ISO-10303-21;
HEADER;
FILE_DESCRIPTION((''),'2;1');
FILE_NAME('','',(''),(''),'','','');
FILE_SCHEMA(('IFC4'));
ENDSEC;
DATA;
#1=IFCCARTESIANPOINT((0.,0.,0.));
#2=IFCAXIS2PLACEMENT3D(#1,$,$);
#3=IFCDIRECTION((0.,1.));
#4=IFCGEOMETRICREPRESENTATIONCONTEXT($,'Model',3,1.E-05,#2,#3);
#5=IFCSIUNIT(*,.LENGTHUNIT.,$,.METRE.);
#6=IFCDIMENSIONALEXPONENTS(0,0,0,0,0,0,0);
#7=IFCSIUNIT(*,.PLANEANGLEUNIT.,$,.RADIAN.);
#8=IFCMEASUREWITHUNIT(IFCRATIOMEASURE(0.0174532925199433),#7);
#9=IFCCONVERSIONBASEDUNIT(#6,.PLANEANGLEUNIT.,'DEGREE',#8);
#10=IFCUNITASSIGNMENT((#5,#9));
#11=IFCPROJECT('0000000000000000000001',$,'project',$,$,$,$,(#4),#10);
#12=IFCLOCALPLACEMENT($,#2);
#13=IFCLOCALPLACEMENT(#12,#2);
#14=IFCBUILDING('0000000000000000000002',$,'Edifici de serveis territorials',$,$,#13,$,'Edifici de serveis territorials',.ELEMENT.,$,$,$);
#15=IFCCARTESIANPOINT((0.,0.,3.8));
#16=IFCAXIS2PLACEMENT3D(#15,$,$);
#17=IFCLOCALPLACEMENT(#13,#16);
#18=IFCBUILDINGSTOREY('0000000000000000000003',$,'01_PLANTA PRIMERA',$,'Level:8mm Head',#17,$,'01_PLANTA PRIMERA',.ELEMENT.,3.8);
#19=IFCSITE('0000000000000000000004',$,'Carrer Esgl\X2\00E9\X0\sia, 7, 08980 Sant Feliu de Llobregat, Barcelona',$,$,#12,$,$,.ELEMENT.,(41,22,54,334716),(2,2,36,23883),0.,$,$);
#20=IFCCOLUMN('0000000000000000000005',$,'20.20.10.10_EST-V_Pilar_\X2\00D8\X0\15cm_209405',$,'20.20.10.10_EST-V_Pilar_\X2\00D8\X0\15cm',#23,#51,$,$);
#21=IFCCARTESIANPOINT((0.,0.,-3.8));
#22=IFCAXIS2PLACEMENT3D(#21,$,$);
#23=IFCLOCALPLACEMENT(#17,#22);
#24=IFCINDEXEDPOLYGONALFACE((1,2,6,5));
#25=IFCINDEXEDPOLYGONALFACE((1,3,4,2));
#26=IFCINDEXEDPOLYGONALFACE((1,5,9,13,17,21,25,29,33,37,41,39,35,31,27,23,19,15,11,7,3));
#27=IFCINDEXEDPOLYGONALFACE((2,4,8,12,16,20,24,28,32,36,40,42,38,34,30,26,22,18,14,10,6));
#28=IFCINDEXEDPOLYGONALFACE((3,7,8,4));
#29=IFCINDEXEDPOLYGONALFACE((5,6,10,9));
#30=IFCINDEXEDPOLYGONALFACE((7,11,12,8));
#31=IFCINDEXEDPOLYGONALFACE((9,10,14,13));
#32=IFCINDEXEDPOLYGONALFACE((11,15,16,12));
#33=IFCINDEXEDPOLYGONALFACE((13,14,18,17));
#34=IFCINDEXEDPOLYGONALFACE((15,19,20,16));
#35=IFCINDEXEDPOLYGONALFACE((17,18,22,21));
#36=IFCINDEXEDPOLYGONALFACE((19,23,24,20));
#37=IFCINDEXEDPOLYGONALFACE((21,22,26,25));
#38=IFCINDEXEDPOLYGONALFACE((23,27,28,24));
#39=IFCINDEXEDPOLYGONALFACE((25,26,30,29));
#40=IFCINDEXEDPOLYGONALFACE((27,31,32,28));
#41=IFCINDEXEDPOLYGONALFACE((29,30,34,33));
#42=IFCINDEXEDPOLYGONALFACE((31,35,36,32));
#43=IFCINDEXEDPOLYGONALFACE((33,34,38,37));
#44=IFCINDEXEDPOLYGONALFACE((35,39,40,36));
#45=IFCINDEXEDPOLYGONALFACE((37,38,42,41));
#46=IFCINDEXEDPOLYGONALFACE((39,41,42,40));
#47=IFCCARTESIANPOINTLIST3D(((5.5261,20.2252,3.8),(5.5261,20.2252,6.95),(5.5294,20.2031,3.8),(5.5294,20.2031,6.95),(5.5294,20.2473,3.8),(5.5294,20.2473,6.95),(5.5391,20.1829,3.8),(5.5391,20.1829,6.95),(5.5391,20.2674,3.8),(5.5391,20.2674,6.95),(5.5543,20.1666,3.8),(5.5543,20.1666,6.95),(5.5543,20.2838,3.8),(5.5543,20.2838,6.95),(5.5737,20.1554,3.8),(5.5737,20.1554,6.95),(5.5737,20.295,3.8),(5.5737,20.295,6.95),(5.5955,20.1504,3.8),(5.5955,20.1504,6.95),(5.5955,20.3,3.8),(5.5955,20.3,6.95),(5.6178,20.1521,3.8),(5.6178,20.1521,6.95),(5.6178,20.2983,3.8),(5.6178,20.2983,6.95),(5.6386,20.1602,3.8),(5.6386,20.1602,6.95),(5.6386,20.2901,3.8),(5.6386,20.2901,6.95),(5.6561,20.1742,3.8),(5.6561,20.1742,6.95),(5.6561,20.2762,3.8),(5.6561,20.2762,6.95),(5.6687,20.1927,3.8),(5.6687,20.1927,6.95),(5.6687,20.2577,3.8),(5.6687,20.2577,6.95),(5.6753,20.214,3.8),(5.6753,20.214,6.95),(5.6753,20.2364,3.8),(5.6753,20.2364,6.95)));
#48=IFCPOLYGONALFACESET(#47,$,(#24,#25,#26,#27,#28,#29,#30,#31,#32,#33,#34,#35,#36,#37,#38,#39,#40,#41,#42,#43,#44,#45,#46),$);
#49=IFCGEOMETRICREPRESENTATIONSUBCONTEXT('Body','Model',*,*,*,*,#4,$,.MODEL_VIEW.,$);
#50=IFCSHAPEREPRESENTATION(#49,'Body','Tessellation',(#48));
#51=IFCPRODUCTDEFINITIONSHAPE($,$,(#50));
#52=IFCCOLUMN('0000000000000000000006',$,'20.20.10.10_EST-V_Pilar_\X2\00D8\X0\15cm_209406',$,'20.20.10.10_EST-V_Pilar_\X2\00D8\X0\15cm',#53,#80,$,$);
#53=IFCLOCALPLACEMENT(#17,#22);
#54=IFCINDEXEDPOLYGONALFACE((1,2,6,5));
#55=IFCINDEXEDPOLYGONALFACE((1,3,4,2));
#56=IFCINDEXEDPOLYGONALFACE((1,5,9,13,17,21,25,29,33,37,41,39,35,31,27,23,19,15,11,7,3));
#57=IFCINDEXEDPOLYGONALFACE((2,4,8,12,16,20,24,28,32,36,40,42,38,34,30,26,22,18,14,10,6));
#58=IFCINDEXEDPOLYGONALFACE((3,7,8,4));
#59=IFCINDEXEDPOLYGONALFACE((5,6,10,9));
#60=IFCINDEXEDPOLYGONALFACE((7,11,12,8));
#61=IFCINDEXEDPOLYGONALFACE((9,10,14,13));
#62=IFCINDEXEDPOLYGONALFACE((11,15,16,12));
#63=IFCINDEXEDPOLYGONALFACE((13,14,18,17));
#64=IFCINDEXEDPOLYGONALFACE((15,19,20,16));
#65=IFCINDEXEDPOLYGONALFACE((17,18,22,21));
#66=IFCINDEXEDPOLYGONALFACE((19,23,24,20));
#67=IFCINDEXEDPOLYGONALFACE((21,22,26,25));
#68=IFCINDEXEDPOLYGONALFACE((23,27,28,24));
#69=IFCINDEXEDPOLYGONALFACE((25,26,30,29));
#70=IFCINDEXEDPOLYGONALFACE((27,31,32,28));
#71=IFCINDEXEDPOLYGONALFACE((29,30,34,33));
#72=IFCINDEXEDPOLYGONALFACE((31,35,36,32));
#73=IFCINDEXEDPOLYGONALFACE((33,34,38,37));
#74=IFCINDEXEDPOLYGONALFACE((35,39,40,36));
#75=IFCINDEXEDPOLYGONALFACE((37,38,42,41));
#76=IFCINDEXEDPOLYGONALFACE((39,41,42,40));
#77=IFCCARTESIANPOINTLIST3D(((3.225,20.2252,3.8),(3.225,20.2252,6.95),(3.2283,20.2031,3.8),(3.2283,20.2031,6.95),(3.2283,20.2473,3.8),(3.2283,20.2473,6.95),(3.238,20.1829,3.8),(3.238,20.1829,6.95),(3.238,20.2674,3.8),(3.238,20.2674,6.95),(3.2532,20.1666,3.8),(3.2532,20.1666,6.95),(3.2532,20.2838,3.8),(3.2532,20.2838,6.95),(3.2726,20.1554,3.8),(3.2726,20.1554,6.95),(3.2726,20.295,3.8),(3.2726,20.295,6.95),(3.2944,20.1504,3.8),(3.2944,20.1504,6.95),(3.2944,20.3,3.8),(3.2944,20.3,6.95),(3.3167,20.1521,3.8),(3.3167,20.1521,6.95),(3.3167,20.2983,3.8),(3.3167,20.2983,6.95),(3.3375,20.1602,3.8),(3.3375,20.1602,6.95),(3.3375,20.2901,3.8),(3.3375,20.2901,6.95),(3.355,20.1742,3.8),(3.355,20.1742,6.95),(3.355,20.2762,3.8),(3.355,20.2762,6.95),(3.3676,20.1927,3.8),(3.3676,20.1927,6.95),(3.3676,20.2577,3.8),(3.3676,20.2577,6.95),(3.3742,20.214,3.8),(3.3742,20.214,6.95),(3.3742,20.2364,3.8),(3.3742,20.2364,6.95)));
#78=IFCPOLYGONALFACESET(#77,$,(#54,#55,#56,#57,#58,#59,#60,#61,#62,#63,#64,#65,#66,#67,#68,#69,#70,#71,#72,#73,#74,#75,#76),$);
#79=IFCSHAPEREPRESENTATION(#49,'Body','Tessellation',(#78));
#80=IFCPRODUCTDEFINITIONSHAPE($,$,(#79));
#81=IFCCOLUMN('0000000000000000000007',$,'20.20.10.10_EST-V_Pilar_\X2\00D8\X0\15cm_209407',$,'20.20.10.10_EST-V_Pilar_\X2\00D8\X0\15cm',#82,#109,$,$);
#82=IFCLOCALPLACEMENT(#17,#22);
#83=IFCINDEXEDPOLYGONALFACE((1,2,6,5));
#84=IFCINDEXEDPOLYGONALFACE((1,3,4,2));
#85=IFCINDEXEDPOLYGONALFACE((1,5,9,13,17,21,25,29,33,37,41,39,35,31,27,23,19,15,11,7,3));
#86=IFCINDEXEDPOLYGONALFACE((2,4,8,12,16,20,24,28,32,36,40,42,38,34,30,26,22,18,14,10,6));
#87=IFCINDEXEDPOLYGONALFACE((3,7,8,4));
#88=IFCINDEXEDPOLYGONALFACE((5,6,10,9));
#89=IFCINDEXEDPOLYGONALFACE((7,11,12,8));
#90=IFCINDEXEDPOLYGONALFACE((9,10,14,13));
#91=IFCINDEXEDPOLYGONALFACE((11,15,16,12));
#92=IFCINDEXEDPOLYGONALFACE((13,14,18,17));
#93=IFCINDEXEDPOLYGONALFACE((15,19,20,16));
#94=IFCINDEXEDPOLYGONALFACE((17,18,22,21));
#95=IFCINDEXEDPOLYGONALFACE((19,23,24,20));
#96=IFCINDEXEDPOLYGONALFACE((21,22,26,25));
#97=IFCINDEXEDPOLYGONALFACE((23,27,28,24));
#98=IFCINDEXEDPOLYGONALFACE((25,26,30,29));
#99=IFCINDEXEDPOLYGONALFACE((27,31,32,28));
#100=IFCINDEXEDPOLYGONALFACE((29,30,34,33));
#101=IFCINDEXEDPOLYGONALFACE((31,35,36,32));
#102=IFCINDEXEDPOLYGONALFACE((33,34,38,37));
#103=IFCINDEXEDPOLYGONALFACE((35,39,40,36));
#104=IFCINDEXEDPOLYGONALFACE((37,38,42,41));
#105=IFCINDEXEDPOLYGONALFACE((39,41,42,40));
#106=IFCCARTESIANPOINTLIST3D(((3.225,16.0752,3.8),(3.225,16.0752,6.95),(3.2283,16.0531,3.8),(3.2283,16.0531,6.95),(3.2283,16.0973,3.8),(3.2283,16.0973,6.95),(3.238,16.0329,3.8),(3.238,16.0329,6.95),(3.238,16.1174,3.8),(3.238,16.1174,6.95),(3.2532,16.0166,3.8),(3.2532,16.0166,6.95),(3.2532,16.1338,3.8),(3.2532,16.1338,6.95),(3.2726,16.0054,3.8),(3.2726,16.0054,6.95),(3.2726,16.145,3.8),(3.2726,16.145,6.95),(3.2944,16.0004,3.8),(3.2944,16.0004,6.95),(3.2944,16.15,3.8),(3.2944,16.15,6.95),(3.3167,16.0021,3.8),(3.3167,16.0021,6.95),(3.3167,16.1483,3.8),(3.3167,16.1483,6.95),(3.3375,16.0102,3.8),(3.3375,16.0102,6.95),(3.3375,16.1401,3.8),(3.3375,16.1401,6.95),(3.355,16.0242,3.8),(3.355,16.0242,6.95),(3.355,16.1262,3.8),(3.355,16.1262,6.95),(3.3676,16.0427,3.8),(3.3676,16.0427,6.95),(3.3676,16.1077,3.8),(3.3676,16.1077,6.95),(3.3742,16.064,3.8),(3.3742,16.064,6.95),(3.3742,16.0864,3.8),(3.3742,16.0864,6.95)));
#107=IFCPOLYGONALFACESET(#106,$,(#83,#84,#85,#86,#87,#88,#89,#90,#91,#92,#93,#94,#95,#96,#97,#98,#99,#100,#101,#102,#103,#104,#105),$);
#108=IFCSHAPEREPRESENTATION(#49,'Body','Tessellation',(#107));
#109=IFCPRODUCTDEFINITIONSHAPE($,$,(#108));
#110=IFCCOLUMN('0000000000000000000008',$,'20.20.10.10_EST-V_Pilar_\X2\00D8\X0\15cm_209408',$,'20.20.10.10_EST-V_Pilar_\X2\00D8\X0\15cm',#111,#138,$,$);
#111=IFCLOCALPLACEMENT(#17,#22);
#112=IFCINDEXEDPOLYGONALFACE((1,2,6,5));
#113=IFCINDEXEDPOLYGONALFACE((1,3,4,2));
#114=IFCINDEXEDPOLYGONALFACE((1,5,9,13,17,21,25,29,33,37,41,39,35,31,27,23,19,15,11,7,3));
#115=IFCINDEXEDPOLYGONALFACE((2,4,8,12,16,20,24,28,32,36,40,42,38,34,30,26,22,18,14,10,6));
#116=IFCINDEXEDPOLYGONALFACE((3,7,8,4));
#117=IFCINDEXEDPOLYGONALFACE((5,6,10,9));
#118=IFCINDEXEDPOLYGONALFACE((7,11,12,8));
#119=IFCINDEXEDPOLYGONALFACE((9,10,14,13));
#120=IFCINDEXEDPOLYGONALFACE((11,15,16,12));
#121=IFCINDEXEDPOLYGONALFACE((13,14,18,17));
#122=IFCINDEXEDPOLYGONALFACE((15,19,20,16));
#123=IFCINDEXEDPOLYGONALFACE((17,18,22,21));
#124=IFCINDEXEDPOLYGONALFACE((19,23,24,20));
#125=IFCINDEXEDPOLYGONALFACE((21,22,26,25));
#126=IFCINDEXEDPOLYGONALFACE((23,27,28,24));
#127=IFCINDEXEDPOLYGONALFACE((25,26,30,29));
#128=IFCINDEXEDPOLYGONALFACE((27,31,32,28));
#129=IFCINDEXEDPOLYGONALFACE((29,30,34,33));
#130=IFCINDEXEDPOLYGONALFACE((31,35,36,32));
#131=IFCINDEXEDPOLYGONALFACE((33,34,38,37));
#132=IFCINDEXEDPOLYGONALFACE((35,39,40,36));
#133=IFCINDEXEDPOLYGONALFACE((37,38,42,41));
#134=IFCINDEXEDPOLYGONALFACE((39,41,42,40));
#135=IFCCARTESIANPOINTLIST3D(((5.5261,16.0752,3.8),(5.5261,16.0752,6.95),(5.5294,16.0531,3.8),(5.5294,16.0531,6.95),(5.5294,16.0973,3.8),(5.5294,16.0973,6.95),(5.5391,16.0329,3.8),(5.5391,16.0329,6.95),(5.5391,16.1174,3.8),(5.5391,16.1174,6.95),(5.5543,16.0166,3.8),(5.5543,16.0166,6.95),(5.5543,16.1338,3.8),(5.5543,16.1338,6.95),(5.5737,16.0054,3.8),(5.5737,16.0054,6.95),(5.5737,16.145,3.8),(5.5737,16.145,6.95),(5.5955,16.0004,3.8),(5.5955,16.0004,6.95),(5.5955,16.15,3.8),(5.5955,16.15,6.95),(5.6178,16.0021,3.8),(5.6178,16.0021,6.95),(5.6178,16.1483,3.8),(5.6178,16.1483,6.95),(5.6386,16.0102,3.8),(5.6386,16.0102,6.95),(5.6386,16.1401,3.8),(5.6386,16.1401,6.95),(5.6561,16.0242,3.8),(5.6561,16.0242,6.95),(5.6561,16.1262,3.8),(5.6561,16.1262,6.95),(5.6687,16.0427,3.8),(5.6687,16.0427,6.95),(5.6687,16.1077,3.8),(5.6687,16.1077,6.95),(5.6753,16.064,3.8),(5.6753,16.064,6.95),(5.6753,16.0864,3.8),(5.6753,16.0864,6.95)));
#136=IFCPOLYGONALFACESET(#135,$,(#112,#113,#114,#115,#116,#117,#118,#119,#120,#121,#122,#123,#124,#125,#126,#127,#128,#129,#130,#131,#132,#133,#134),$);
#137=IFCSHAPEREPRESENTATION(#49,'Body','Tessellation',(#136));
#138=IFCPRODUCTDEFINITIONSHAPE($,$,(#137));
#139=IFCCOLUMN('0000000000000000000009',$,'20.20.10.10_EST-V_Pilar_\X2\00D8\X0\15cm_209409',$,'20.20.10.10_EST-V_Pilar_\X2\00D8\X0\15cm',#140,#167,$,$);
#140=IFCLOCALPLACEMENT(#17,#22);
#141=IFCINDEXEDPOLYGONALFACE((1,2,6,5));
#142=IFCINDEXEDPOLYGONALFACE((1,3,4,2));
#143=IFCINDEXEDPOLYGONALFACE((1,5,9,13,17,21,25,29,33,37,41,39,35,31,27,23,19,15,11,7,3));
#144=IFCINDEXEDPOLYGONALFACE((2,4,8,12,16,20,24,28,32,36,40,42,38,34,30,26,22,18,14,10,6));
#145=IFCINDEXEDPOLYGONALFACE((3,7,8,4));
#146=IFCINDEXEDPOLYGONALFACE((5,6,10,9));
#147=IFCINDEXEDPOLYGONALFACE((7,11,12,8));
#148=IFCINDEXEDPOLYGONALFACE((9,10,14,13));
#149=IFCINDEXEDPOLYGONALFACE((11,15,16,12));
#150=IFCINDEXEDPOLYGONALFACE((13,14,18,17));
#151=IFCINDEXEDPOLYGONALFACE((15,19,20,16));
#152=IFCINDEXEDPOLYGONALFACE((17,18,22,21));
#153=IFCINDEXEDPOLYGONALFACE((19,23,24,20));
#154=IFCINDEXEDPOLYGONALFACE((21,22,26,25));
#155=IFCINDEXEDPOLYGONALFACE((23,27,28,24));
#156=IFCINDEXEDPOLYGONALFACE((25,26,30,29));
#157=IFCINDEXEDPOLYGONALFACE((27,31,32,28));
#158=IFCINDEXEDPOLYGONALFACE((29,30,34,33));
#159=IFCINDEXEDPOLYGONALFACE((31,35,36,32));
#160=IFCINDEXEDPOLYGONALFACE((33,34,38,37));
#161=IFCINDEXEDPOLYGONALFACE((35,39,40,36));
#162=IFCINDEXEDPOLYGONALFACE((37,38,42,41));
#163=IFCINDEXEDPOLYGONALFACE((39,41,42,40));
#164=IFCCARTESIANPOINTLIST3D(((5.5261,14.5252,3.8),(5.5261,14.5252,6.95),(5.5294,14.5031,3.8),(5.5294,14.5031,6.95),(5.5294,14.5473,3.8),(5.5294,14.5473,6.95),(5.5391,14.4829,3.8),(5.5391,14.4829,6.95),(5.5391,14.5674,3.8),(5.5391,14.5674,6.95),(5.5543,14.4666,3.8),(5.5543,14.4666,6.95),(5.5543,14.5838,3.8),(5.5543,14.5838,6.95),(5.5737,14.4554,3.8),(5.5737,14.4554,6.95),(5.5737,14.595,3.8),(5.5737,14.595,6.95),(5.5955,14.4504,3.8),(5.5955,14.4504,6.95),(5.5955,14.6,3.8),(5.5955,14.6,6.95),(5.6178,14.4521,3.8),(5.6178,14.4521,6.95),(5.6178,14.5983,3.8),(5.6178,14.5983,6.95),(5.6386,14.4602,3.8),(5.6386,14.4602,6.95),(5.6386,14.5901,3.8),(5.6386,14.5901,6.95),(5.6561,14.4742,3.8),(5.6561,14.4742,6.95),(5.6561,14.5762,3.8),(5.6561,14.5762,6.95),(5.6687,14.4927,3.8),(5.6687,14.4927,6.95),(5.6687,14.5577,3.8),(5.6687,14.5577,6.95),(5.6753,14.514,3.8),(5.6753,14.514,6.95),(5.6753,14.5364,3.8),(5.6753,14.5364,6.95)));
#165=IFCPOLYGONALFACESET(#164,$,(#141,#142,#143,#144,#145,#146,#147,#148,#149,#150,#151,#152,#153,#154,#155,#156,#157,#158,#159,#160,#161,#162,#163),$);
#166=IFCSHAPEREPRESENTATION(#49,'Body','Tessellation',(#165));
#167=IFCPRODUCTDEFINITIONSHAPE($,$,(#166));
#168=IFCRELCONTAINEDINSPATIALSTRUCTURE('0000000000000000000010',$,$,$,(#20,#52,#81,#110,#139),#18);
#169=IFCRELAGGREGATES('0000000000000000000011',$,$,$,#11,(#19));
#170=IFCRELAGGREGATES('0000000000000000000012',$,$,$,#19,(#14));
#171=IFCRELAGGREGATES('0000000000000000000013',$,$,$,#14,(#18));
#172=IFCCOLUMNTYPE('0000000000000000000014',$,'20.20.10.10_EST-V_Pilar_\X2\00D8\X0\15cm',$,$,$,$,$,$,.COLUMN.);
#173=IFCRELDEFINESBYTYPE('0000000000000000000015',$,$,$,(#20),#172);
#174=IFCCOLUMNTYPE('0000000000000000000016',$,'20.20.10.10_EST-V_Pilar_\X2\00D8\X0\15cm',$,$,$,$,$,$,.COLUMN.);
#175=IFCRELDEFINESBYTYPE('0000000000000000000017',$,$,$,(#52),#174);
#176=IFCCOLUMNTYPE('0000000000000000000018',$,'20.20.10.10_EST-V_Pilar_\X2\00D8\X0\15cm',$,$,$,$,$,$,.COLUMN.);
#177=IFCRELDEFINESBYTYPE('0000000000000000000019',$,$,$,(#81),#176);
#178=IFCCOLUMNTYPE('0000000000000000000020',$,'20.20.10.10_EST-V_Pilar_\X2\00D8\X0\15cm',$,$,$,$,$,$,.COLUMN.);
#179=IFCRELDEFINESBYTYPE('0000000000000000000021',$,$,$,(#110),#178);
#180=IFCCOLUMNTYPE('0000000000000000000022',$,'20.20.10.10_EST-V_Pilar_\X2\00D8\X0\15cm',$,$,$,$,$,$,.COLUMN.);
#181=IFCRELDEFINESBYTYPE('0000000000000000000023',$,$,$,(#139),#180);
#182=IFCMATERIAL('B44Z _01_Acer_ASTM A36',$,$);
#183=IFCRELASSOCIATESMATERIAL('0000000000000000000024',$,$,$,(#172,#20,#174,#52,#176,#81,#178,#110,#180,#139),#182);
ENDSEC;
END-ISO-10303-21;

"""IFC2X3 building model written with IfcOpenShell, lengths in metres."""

from ifc_helpers import new_model, entity, si_unit, converted_unit, direction, frame, origin, origin_2d_with_axis, place, context, subcontext, project, spatial, circle, extrude, source, transform, mapped, material, type_object, type_shapes, element, save


model = new_model("IFC2X3")

# Units and contexts
model_context = context("Model", 3, precision=1e-05, world=origin(), true_north=direction((0.0, 1.0)))
body_context = subcontext(model_context, "Body", "Model", "MODEL_VIEW")
ifc_project = project(units=[si_unit("LENGTHUNIT", "METRE"), converted_unit("PLANEANGLEUNIT", "DEGREE", entity("IfcRatioMeasure", 0.0174532925199433), si_unit("PLANEANGLEUNIT", "RADIAN"), dimensions=[0, 0, 0, 0, 0, 0, 0])], contexts=[model_context])

# Site, building, storey
site_placement = place(None, origin())
site = spatial("IfcSite", under=ifc_project, at=site_placement, Name="Carrer Església, 7, 08980 Sant Feliu de Llobregat, Barcelona", CompositionType="ELEMENT", RefLatitude=(41, 22, 54, 334716), RefLongitude=(2, 2, 36, 23883), RefElevation=0.0)
building_placement = place(site_placement, origin())
building = spatial("IfcBuilding", under=site, at=building_placement, Name="Edifici de serveis territorials", LongName="Edifici de serveis territorials", CompositionType="ELEMENT")
storey_placement = place(building_placement, frame((0.0, 0.0, 3.8)))
storey = spatial("IfcBuildingStorey", under=building, at=storey_placement, Name="01_PLANTA PRIMERA", ObjectType="Level:8mm Head", LongName="01_PLANTA PRIMERA", CompositionType="ELEMENT", Elevation=3.8)

# Columns
ifc_material_1 = material(Name="B44Z _01_Acer_ASTM A36")
column_type_1 = type_object("IfcColumnType", Name="20.20.10.10_EST-V_Pilar_Ø15cm", PredefinedType="COLUMN", material=ifc_material_1)
shared_shape_1 = source(origin(), body_context, "Body", "SweptSolid", [
    extrude(circle(Radius=0.075, at=origin_2d_with_axis()), frame((5.6011, 20.2252, 3.8), z_axis=(0.0, 0.0, 1.0), x_axis=(-1.0, 0.0, 0.0)), (0.0, 0.0, 1.0), 3.15),
])
type_shapes(column_type_1, [shared_shape_1])
column_1_placement = place(storey_placement, frame((0.0, 0.0, -3.8)))
element("IfcColumn", 1, at=column_1_placement, inside=storey, type_object=column_type_1, material=ifc_material_1, Name="20.20.10.10_EST-V_Pilar_Ø15cm_209405", ObjectType="20.20.10.10_EST-V_Pilar_Ø15cm", context=body_context, shape_type="MappedRepresentation", body=[
    mapped(shared_shape_1, transform((0.0, 0.0, 0.0), scale=1.0)),
])
column_type_2 = type_object("IfcColumnType", Name="20.20.10.10_EST-V_Pilar_Ø15cm", PredefinedType="COLUMN", material=ifc_material_1)
shared_shape_2 = source(origin(), body_context, "Body", "SweptSolid", [
    extrude(circle(Radius=0.075, at=origin_2d_with_axis()), frame((3.3, 20.2252, 3.8), z_axis=(0.0, 0.0, 1.0), x_axis=(-1.0, 0.0, 0.0)), (0.0, 0.0, 1.0), 3.15),
])
type_shapes(column_type_2, [shared_shape_2])
column_2_placement = place(storey_placement, frame((0.0, 0.0, -3.8)))
element("IfcColumn", 2, at=column_2_placement, inside=storey, type_object=column_type_2, material=ifc_material_1, Name="20.20.10.10_EST-V_Pilar_Ø15cm_209406", ObjectType="20.20.10.10_EST-V_Pilar_Ø15cm", context=body_context, shape_type="MappedRepresentation", body=[
    mapped(shared_shape_2, transform((0.0, 0.0, 0.0), scale=1.0)),
])
column_type_3 = type_object("IfcColumnType", Name="20.20.10.10_EST-V_Pilar_Ø15cm", PredefinedType="COLUMN", material=ifc_material_1)
shared_shape_3 = source(origin(), body_context, "Body", "SweptSolid", [
    extrude(circle(Radius=0.075, at=origin_2d_with_axis()), frame((3.3, 16.0752, 3.8), z_axis=(0.0, 0.0, 1.0), x_axis=(-1.0, 0.0, 0.0)), (0.0, 0.0, 1.0), 3.15),
])
type_shapes(column_type_3, [shared_shape_3])
column_3_placement = place(storey_placement, frame((0.0, 0.0, -3.8)))
element("IfcColumn", 3, at=column_3_placement, inside=storey, type_object=column_type_3, material=ifc_material_1, Name="20.20.10.10_EST-V_Pilar_Ø15cm_209407", ObjectType="20.20.10.10_EST-V_Pilar_Ø15cm", context=body_context, shape_type="MappedRepresentation", body=[
    mapped(shared_shape_3, transform((0.0, 0.0, 0.0), scale=1.0)),
])
column_type_4 = type_object("IfcColumnType", Name="20.20.10.10_EST-V_Pilar_Ø15cm", PredefinedType="COLUMN", material=ifc_material_1)
shared_shape_4 = source(origin(), body_context, "Body", "SweptSolid", [
    extrude(circle(Radius=0.075, at=origin_2d_with_axis()), frame((5.6011, 16.0752, 3.8), z_axis=(0.0, 0.0, 1.0), x_axis=(-1.0, 0.0, 0.0)), (0.0, 0.0, 1.0), 3.15),
])
type_shapes(column_type_4, [shared_shape_4])
column_4_placement = place(storey_placement, frame((0.0, 0.0, -3.8)))
element("IfcColumn", 4, at=column_4_placement, inside=storey, type_object=column_type_4, material=ifc_material_1, Name="20.20.10.10_EST-V_Pilar_Ø15cm_209408", ObjectType="20.20.10.10_EST-V_Pilar_Ø15cm", context=body_context, shape_type="MappedRepresentation", body=[
    mapped(shared_shape_4, transform((0.0, 0.0, 0.0), scale=1.0)),
])
column_type_5 = type_object("IfcColumnType", Name="20.20.10.10_EST-V_Pilar_Ø15cm", PredefinedType="COLUMN", material=ifc_material_1)
shared_shape_5 = source(origin(), body_context, "Body", "SweptSolid", [
    extrude(circle(Radius=0.075, at=origin_2d_with_axis()), frame((5.6011, 14.5252, 3.8), z_axis=(0.0, 0.0, 1.0), x_axis=(-1.0, 0.0, 0.0)), (0.0, 0.0, 1.0), 3.15),
])
type_shapes(column_type_5, [shared_shape_5])
column_5_placement = place(storey_placement, frame((0.0, 0.0, -3.8)))
element("IfcColumn", 5, at=column_5_placement, inside=storey, type_object=column_type_5, material=ifc_material_1, Name="20.20.10.10_EST-V_Pilar_Ø15cm_209409", ObjectType="20.20.10.10_EST-V_Pilar_Ø15cm", context=body_context, shape_type="MappedRepresentation", body=[
    mapped(shared_shape_5, transform((0.0, 0.0, 0.0), scale=1.0)),
])

save(model, "model.ifc")
